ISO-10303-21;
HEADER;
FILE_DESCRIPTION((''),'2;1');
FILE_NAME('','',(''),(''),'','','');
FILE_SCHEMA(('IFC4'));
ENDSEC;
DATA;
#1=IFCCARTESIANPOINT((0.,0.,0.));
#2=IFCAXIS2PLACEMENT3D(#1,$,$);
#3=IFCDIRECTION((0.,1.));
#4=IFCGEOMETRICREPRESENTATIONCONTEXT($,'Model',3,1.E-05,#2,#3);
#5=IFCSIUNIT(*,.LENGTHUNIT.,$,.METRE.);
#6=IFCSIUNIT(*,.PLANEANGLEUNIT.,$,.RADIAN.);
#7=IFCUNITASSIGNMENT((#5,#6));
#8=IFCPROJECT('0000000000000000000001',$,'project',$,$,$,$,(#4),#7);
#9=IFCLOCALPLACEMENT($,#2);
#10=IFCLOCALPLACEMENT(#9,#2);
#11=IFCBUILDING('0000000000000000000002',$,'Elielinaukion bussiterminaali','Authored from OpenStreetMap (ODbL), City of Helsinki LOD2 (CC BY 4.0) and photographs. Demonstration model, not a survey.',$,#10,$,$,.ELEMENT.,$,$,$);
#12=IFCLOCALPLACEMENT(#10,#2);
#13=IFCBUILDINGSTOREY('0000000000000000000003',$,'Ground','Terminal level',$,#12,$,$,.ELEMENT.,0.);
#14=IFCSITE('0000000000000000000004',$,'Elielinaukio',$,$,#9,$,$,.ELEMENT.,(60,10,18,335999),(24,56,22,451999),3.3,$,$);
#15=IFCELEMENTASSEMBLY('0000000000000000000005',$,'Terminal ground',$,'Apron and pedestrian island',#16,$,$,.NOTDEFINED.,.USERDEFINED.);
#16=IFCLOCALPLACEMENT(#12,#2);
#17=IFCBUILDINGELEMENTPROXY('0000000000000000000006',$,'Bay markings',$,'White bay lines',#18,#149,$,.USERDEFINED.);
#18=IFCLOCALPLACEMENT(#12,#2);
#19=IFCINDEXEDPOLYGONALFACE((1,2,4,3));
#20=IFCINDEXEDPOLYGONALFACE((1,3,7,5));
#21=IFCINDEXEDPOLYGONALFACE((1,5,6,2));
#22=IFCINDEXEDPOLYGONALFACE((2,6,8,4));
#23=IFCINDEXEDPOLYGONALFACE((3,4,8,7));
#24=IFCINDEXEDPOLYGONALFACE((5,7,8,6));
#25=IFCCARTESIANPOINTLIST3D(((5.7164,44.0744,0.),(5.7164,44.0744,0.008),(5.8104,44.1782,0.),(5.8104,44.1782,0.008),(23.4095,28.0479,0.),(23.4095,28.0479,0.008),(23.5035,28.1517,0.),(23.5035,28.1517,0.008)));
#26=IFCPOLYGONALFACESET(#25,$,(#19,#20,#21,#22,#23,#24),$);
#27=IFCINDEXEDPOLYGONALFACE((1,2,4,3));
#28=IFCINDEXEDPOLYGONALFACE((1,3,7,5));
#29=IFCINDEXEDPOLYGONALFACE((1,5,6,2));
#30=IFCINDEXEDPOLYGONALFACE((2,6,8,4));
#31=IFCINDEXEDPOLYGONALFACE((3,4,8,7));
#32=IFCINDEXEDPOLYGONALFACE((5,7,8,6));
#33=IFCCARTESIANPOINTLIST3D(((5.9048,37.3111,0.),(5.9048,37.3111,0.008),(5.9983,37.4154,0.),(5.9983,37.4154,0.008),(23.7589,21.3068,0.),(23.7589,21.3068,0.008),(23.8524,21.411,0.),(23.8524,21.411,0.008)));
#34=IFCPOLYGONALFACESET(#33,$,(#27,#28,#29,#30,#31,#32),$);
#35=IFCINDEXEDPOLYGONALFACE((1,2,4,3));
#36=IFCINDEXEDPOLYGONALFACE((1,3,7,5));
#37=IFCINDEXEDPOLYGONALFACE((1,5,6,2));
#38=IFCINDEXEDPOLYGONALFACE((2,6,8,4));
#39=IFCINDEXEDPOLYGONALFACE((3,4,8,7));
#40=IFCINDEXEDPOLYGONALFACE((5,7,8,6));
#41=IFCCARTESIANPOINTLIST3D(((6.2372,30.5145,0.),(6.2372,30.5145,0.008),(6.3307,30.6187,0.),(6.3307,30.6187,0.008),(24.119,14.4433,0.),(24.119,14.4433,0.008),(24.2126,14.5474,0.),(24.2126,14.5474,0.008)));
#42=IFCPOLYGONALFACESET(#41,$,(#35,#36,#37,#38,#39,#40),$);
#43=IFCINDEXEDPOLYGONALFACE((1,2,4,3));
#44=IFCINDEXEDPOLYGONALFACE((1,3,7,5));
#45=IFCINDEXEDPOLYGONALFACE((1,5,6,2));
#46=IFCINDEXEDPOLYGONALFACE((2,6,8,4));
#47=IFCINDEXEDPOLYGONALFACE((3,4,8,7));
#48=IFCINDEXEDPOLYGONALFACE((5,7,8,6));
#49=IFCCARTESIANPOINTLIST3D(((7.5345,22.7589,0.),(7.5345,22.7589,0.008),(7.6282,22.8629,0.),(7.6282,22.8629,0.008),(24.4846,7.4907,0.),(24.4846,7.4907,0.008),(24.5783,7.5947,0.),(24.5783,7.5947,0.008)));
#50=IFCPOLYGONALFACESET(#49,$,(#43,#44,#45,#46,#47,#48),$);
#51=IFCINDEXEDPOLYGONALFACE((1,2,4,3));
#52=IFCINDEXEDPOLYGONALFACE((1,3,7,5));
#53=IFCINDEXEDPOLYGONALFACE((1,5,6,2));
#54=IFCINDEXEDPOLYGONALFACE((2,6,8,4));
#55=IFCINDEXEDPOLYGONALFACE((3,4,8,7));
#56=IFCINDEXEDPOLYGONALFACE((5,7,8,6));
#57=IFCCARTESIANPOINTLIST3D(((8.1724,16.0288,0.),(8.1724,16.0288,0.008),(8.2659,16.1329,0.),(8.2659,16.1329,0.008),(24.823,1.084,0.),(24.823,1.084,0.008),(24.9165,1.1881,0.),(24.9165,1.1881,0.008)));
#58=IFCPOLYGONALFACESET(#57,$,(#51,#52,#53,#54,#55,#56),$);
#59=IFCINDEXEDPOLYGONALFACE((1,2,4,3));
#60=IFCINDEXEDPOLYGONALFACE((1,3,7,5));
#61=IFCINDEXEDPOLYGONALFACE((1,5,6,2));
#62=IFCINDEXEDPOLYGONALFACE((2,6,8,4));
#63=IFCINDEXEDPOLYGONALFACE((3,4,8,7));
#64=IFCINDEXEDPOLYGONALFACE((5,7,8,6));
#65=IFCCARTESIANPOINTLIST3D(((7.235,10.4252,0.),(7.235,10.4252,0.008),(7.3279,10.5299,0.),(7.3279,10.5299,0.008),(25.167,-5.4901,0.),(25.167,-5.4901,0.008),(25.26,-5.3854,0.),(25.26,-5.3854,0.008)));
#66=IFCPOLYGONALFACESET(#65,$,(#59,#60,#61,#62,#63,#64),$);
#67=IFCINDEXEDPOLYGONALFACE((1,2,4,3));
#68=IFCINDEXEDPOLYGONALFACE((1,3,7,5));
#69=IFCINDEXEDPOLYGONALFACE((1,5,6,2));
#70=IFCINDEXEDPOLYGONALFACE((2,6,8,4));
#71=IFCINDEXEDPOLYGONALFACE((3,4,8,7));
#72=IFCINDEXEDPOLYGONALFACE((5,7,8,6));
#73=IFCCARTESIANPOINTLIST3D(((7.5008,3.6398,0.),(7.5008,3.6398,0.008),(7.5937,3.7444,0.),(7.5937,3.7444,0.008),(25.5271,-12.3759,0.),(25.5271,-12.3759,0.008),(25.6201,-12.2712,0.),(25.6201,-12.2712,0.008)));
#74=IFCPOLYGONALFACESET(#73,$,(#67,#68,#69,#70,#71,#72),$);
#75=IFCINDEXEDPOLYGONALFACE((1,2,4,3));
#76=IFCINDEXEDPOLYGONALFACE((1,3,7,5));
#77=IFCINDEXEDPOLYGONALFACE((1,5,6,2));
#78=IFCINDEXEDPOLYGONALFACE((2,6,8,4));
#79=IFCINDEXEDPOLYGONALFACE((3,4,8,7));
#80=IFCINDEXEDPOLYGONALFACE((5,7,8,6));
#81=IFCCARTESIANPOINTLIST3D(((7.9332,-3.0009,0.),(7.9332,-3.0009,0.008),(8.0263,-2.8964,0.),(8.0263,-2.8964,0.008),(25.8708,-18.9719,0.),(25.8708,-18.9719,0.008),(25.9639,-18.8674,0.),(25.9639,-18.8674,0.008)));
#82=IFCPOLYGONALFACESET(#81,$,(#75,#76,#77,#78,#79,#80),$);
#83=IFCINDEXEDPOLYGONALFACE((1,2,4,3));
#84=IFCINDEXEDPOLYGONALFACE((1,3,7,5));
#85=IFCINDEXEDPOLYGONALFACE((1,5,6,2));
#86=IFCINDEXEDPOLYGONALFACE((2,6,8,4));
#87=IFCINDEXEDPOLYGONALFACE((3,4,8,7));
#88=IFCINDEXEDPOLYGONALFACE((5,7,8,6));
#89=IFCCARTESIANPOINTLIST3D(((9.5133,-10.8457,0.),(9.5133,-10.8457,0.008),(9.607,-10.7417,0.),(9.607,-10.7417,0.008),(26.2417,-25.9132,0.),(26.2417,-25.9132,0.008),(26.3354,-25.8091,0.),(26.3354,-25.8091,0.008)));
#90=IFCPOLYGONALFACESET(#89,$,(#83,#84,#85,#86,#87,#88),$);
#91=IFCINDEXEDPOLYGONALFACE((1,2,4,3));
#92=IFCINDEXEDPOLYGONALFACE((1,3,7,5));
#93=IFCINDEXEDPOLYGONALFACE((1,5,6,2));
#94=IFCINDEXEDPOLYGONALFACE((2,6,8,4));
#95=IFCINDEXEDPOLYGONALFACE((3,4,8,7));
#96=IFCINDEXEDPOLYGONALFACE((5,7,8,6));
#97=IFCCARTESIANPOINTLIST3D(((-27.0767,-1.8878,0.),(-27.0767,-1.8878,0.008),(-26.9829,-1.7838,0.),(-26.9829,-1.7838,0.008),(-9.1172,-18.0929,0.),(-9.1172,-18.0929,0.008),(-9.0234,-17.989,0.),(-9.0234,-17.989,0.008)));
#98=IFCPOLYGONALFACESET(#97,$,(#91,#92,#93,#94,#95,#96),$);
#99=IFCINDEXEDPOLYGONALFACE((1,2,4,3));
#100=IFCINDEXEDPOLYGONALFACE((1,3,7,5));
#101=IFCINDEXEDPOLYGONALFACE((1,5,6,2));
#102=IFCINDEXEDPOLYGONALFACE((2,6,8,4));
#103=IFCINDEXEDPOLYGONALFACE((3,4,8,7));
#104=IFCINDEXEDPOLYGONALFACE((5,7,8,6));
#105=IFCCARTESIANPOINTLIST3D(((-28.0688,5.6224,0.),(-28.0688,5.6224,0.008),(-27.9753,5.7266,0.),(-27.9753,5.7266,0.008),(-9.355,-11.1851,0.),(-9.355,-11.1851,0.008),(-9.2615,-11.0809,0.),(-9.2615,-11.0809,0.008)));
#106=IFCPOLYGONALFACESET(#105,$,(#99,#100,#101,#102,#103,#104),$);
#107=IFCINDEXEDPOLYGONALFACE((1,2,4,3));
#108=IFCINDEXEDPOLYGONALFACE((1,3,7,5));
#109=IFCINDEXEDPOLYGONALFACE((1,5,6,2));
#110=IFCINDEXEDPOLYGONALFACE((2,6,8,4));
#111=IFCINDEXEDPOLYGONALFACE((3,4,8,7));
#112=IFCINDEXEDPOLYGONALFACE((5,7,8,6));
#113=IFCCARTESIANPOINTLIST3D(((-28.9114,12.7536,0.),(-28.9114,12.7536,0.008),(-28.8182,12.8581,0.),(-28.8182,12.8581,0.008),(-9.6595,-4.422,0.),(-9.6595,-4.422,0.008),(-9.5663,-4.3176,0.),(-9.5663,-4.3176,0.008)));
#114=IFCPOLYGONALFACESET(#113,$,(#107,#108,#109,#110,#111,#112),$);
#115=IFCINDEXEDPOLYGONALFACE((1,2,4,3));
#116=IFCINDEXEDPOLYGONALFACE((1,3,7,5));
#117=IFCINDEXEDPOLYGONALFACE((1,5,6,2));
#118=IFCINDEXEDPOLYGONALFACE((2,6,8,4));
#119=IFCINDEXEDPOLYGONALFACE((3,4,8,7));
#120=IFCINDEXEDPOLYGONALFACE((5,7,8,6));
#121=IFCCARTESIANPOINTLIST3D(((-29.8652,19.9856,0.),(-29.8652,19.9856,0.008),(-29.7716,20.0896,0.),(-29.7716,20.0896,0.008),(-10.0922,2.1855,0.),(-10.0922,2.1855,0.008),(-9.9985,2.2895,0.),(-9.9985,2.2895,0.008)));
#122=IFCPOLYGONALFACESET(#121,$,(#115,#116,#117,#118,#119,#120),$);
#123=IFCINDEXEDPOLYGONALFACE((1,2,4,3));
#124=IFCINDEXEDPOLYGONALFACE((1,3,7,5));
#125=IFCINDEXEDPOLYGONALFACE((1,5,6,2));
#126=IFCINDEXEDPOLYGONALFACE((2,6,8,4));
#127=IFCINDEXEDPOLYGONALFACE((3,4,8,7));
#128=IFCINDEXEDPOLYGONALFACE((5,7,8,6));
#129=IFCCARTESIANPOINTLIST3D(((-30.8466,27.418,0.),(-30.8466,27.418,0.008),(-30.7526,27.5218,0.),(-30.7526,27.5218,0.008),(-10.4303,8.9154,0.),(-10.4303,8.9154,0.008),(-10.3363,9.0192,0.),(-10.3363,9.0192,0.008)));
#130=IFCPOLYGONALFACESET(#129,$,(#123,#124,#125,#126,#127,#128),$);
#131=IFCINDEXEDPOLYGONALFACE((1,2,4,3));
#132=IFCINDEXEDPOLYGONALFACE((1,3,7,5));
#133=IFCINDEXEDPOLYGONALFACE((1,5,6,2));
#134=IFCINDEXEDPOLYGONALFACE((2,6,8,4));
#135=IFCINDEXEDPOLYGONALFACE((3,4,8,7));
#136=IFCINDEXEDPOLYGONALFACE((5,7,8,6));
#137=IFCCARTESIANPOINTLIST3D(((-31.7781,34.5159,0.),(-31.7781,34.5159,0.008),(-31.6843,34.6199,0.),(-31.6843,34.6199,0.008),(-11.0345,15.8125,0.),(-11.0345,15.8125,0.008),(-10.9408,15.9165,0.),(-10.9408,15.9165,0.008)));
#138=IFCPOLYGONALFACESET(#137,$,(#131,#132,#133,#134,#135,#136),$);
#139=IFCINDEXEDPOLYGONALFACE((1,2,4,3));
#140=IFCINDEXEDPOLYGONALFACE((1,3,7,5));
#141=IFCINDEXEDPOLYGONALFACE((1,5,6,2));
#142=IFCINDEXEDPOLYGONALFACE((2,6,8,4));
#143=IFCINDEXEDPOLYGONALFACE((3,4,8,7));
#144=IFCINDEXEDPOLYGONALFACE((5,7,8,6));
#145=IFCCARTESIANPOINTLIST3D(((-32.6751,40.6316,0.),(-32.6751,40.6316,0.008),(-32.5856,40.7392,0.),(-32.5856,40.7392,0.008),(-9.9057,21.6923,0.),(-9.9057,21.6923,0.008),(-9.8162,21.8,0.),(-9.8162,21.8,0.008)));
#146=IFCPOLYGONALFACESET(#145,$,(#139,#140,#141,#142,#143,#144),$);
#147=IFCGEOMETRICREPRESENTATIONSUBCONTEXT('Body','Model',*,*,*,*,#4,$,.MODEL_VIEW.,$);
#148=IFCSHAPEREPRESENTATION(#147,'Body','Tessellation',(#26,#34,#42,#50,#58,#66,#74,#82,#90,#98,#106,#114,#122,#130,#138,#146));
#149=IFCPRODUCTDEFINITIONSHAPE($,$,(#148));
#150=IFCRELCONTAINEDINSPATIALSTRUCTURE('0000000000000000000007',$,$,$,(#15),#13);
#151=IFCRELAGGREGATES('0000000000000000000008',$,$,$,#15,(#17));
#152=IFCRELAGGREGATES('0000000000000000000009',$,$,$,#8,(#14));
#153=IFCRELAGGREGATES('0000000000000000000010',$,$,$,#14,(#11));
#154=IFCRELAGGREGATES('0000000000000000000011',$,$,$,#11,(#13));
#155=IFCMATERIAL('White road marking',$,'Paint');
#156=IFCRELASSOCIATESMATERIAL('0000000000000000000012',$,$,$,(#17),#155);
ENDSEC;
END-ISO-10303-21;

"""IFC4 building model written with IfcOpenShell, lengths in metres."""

from ifc_helpers import new_model, si_unit, direction, origin, place, context, subcontext, project, spatial, polyline, outline, extrude, material, element, aggregate, save


model = new_model("IFC4")

# Units and contexts
model_context = context("Model", 3, precision=1e-05, world=origin(), true_north=direction((0.0, 1.0)))
body_context = subcontext(model_context, "Body", "Model", "MODEL_VIEW")
ifc_project = project(units=[si_unit("LENGTHUNIT", "METRE"), si_unit("PLANEANGLEUNIT", "RADIAN")], contexts=[model_context])

# Site, building, storey
site_placement = place(None, origin())
site = spatial("IfcSite", under=ifc_project, at=site_placement, Name="Elielinaukio", CompositionType="ELEMENT", RefLatitude=(60, 10, 18, 335999), RefLongitude=(24, 56, 22, 451999), RefElevation=3.3)
building_placement = place(site_placement, origin())
building = spatial("IfcBuilding", under=site, at=building_placement, Name="Elielinaukion bussiterminaali", Description="Authored from OpenStreetMap (ODbL), City of Helsinki LOD2 (CC BY 4.0) and photographs. Demonstration model, not a survey.", CompositionType="ELEMENT")
storey_placement = place(building_placement, origin())
storey = spatial("IfcBuildingStorey", under=building, at=storey_placement, Name="Ground", Description="Terminal level", CompositionType="ELEMENT", Elevation=0.0)

# Element assembly
assembly_1_placement = place(building_placement, origin())
assembly_1 = element("IfcElementAssembly", 1, at=assembly_1_placement, inside=storey, Name="Terminal ground", ObjectType="Apron and pedestrian island", AssemblyPlace="NOTDEFINED", PredefinedType="USERDEFINED")

# Building element proxy
ifc_material_1 = material(Name="White road marking", Category="Paint")
proxy_placement = place(building_placement, origin())
proxy = element("IfcBuildingElementProxy", 2, at=proxy_placement, material=ifc_material_1, Name="Bay markings", ObjectType="White bay lines", PredefinedType="USERDEFINED", context=body_context, shape_type="SweptSolid", body=[
    extrude(outline(polyline([(23.5035, 28.1517), (23.4095, 28.0479), (5.7164, 44.0744), (5.8104, 44.1782), (23.5035, 28.1517)])), origin(), (0.0, 0.0, 1.0), 0.008),
    extrude(outline(polyline([(23.8524, 21.411), (23.7589, 21.3068), (5.9048, 37.3111), (5.9983, 37.4154), (23.8524, 21.411)])), origin(), (0.0, 0.0, 1.0), 0.008),
    extrude(outline(polyline([(24.2126, 14.5474), (24.119, 14.4433), (6.2372, 30.5145), (6.3307, 30.6187), (24.2126, 14.5474)])), origin(), (0.0, 0.0, 1.0), 0.008),
    extrude(outline(polyline([(24.5783, 7.5947), (24.4846, 7.4907), (7.5345, 22.7589), (7.6282, 22.8629), (24.5783, 7.5947)])), origin(), (0.0, 0.0, 1.0), 0.008),
    extrude(outline(polyline([(24.9165, 1.1881), (24.823, 1.084), (8.1724, 16.0288), (8.2659, 16.1329), (24.9165, 1.1881)])), origin(), (0.0, 0.0, 1.0), 0.008),
    extrude(outline(polyline([(25.26, -5.3854), (25.167, -5.4901), (7.235, 10.4252), (7.3279, 10.5299), (25.26, -5.3854)])), origin(), (0.0, 0.0, 1.0), 0.008),
    extrude(outline(polyline([(25.6201, -12.2712), (25.5271, -12.3759), (7.5008, 3.6398), (7.5937, 3.7444), (25.6201, -12.2712)])), origin(), (0.0, 0.0, 1.0), 0.008),
    extrude(outline(polyline([(25.9639, -18.8674), (25.8708, -18.9719), (7.9332, -3.0009), (8.0263, -2.8964), (25.9639, -18.8674)])), origin(), (0.0, 0.0, 1.0), 0.008),
    extrude(outline(polyline([(26.3354, -25.8091), (26.2417, -25.9132), (9.5133, -10.8457), (9.607, -10.7417), (26.3354, -25.8091)])), origin(), (0.0, 0.0, 1.0), 0.008),
    extrude(outline(polyline([(-27.0767, -1.8878), (-26.9829, -1.7838), (-9.0234, -17.989), (-9.1172, -18.0929), (-27.0767, -1.8878)])), origin(), (0.0, 0.0, 1.0), 0.008),
    extrude(outline(polyline([(-28.0688, 5.6224), (-27.9753, 5.7266), (-9.2615, -11.0809), (-9.355, -11.1851), (-28.0688, 5.6224)])), origin(), (0.0, 0.0, 1.0), 0.008),
    extrude(outline(polyline([(-28.9114, 12.7536), (-28.8182, 12.8581), (-9.5663, -4.3176), (-9.6595, -4.422), (-28.9114, 12.7536)])), origin(), (0.0, 0.0, 1.0), 0.008),
    extrude(outline(polyline([(-29.8652, 19.9856), (-29.7716, 20.0896), (-9.9985, 2.2895), (-10.0922, 2.1855), (-29.8652, 19.9856)])), origin(), (0.0, 0.0, 1.0), 0.008),
    extrude(outline(polyline([(-30.8466, 27.418), (-30.7526, 27.5218), (-10.3363, 9.0192), (-10.4303, 8.9154), (-30.8466, 27.418)])), origin(), (0.0, 0.0, 1.0), 0.008),
    extrude(outline(polyline([(-31.7781, 34.5159), (-31.6843, 34.6199), (-10.9408, 15.9165), (-11.0345, 15.8125), (-31.7781, 34.5159)])), origin(), (0.0, 0.0, 1.0), 0.008),
    extrude(outline(polyline([(-32.6751, 40.6316), (-32.5856, 40.7392), (-9.8162, 21.8), (-9.9057, 21.6923), (-32.6751, 40.6316)])), origin(), (0.0, 0.0, 1.0), 0.008),
])
aggregate(assembly_1, [proxy])

save(model, "model.ifc")
